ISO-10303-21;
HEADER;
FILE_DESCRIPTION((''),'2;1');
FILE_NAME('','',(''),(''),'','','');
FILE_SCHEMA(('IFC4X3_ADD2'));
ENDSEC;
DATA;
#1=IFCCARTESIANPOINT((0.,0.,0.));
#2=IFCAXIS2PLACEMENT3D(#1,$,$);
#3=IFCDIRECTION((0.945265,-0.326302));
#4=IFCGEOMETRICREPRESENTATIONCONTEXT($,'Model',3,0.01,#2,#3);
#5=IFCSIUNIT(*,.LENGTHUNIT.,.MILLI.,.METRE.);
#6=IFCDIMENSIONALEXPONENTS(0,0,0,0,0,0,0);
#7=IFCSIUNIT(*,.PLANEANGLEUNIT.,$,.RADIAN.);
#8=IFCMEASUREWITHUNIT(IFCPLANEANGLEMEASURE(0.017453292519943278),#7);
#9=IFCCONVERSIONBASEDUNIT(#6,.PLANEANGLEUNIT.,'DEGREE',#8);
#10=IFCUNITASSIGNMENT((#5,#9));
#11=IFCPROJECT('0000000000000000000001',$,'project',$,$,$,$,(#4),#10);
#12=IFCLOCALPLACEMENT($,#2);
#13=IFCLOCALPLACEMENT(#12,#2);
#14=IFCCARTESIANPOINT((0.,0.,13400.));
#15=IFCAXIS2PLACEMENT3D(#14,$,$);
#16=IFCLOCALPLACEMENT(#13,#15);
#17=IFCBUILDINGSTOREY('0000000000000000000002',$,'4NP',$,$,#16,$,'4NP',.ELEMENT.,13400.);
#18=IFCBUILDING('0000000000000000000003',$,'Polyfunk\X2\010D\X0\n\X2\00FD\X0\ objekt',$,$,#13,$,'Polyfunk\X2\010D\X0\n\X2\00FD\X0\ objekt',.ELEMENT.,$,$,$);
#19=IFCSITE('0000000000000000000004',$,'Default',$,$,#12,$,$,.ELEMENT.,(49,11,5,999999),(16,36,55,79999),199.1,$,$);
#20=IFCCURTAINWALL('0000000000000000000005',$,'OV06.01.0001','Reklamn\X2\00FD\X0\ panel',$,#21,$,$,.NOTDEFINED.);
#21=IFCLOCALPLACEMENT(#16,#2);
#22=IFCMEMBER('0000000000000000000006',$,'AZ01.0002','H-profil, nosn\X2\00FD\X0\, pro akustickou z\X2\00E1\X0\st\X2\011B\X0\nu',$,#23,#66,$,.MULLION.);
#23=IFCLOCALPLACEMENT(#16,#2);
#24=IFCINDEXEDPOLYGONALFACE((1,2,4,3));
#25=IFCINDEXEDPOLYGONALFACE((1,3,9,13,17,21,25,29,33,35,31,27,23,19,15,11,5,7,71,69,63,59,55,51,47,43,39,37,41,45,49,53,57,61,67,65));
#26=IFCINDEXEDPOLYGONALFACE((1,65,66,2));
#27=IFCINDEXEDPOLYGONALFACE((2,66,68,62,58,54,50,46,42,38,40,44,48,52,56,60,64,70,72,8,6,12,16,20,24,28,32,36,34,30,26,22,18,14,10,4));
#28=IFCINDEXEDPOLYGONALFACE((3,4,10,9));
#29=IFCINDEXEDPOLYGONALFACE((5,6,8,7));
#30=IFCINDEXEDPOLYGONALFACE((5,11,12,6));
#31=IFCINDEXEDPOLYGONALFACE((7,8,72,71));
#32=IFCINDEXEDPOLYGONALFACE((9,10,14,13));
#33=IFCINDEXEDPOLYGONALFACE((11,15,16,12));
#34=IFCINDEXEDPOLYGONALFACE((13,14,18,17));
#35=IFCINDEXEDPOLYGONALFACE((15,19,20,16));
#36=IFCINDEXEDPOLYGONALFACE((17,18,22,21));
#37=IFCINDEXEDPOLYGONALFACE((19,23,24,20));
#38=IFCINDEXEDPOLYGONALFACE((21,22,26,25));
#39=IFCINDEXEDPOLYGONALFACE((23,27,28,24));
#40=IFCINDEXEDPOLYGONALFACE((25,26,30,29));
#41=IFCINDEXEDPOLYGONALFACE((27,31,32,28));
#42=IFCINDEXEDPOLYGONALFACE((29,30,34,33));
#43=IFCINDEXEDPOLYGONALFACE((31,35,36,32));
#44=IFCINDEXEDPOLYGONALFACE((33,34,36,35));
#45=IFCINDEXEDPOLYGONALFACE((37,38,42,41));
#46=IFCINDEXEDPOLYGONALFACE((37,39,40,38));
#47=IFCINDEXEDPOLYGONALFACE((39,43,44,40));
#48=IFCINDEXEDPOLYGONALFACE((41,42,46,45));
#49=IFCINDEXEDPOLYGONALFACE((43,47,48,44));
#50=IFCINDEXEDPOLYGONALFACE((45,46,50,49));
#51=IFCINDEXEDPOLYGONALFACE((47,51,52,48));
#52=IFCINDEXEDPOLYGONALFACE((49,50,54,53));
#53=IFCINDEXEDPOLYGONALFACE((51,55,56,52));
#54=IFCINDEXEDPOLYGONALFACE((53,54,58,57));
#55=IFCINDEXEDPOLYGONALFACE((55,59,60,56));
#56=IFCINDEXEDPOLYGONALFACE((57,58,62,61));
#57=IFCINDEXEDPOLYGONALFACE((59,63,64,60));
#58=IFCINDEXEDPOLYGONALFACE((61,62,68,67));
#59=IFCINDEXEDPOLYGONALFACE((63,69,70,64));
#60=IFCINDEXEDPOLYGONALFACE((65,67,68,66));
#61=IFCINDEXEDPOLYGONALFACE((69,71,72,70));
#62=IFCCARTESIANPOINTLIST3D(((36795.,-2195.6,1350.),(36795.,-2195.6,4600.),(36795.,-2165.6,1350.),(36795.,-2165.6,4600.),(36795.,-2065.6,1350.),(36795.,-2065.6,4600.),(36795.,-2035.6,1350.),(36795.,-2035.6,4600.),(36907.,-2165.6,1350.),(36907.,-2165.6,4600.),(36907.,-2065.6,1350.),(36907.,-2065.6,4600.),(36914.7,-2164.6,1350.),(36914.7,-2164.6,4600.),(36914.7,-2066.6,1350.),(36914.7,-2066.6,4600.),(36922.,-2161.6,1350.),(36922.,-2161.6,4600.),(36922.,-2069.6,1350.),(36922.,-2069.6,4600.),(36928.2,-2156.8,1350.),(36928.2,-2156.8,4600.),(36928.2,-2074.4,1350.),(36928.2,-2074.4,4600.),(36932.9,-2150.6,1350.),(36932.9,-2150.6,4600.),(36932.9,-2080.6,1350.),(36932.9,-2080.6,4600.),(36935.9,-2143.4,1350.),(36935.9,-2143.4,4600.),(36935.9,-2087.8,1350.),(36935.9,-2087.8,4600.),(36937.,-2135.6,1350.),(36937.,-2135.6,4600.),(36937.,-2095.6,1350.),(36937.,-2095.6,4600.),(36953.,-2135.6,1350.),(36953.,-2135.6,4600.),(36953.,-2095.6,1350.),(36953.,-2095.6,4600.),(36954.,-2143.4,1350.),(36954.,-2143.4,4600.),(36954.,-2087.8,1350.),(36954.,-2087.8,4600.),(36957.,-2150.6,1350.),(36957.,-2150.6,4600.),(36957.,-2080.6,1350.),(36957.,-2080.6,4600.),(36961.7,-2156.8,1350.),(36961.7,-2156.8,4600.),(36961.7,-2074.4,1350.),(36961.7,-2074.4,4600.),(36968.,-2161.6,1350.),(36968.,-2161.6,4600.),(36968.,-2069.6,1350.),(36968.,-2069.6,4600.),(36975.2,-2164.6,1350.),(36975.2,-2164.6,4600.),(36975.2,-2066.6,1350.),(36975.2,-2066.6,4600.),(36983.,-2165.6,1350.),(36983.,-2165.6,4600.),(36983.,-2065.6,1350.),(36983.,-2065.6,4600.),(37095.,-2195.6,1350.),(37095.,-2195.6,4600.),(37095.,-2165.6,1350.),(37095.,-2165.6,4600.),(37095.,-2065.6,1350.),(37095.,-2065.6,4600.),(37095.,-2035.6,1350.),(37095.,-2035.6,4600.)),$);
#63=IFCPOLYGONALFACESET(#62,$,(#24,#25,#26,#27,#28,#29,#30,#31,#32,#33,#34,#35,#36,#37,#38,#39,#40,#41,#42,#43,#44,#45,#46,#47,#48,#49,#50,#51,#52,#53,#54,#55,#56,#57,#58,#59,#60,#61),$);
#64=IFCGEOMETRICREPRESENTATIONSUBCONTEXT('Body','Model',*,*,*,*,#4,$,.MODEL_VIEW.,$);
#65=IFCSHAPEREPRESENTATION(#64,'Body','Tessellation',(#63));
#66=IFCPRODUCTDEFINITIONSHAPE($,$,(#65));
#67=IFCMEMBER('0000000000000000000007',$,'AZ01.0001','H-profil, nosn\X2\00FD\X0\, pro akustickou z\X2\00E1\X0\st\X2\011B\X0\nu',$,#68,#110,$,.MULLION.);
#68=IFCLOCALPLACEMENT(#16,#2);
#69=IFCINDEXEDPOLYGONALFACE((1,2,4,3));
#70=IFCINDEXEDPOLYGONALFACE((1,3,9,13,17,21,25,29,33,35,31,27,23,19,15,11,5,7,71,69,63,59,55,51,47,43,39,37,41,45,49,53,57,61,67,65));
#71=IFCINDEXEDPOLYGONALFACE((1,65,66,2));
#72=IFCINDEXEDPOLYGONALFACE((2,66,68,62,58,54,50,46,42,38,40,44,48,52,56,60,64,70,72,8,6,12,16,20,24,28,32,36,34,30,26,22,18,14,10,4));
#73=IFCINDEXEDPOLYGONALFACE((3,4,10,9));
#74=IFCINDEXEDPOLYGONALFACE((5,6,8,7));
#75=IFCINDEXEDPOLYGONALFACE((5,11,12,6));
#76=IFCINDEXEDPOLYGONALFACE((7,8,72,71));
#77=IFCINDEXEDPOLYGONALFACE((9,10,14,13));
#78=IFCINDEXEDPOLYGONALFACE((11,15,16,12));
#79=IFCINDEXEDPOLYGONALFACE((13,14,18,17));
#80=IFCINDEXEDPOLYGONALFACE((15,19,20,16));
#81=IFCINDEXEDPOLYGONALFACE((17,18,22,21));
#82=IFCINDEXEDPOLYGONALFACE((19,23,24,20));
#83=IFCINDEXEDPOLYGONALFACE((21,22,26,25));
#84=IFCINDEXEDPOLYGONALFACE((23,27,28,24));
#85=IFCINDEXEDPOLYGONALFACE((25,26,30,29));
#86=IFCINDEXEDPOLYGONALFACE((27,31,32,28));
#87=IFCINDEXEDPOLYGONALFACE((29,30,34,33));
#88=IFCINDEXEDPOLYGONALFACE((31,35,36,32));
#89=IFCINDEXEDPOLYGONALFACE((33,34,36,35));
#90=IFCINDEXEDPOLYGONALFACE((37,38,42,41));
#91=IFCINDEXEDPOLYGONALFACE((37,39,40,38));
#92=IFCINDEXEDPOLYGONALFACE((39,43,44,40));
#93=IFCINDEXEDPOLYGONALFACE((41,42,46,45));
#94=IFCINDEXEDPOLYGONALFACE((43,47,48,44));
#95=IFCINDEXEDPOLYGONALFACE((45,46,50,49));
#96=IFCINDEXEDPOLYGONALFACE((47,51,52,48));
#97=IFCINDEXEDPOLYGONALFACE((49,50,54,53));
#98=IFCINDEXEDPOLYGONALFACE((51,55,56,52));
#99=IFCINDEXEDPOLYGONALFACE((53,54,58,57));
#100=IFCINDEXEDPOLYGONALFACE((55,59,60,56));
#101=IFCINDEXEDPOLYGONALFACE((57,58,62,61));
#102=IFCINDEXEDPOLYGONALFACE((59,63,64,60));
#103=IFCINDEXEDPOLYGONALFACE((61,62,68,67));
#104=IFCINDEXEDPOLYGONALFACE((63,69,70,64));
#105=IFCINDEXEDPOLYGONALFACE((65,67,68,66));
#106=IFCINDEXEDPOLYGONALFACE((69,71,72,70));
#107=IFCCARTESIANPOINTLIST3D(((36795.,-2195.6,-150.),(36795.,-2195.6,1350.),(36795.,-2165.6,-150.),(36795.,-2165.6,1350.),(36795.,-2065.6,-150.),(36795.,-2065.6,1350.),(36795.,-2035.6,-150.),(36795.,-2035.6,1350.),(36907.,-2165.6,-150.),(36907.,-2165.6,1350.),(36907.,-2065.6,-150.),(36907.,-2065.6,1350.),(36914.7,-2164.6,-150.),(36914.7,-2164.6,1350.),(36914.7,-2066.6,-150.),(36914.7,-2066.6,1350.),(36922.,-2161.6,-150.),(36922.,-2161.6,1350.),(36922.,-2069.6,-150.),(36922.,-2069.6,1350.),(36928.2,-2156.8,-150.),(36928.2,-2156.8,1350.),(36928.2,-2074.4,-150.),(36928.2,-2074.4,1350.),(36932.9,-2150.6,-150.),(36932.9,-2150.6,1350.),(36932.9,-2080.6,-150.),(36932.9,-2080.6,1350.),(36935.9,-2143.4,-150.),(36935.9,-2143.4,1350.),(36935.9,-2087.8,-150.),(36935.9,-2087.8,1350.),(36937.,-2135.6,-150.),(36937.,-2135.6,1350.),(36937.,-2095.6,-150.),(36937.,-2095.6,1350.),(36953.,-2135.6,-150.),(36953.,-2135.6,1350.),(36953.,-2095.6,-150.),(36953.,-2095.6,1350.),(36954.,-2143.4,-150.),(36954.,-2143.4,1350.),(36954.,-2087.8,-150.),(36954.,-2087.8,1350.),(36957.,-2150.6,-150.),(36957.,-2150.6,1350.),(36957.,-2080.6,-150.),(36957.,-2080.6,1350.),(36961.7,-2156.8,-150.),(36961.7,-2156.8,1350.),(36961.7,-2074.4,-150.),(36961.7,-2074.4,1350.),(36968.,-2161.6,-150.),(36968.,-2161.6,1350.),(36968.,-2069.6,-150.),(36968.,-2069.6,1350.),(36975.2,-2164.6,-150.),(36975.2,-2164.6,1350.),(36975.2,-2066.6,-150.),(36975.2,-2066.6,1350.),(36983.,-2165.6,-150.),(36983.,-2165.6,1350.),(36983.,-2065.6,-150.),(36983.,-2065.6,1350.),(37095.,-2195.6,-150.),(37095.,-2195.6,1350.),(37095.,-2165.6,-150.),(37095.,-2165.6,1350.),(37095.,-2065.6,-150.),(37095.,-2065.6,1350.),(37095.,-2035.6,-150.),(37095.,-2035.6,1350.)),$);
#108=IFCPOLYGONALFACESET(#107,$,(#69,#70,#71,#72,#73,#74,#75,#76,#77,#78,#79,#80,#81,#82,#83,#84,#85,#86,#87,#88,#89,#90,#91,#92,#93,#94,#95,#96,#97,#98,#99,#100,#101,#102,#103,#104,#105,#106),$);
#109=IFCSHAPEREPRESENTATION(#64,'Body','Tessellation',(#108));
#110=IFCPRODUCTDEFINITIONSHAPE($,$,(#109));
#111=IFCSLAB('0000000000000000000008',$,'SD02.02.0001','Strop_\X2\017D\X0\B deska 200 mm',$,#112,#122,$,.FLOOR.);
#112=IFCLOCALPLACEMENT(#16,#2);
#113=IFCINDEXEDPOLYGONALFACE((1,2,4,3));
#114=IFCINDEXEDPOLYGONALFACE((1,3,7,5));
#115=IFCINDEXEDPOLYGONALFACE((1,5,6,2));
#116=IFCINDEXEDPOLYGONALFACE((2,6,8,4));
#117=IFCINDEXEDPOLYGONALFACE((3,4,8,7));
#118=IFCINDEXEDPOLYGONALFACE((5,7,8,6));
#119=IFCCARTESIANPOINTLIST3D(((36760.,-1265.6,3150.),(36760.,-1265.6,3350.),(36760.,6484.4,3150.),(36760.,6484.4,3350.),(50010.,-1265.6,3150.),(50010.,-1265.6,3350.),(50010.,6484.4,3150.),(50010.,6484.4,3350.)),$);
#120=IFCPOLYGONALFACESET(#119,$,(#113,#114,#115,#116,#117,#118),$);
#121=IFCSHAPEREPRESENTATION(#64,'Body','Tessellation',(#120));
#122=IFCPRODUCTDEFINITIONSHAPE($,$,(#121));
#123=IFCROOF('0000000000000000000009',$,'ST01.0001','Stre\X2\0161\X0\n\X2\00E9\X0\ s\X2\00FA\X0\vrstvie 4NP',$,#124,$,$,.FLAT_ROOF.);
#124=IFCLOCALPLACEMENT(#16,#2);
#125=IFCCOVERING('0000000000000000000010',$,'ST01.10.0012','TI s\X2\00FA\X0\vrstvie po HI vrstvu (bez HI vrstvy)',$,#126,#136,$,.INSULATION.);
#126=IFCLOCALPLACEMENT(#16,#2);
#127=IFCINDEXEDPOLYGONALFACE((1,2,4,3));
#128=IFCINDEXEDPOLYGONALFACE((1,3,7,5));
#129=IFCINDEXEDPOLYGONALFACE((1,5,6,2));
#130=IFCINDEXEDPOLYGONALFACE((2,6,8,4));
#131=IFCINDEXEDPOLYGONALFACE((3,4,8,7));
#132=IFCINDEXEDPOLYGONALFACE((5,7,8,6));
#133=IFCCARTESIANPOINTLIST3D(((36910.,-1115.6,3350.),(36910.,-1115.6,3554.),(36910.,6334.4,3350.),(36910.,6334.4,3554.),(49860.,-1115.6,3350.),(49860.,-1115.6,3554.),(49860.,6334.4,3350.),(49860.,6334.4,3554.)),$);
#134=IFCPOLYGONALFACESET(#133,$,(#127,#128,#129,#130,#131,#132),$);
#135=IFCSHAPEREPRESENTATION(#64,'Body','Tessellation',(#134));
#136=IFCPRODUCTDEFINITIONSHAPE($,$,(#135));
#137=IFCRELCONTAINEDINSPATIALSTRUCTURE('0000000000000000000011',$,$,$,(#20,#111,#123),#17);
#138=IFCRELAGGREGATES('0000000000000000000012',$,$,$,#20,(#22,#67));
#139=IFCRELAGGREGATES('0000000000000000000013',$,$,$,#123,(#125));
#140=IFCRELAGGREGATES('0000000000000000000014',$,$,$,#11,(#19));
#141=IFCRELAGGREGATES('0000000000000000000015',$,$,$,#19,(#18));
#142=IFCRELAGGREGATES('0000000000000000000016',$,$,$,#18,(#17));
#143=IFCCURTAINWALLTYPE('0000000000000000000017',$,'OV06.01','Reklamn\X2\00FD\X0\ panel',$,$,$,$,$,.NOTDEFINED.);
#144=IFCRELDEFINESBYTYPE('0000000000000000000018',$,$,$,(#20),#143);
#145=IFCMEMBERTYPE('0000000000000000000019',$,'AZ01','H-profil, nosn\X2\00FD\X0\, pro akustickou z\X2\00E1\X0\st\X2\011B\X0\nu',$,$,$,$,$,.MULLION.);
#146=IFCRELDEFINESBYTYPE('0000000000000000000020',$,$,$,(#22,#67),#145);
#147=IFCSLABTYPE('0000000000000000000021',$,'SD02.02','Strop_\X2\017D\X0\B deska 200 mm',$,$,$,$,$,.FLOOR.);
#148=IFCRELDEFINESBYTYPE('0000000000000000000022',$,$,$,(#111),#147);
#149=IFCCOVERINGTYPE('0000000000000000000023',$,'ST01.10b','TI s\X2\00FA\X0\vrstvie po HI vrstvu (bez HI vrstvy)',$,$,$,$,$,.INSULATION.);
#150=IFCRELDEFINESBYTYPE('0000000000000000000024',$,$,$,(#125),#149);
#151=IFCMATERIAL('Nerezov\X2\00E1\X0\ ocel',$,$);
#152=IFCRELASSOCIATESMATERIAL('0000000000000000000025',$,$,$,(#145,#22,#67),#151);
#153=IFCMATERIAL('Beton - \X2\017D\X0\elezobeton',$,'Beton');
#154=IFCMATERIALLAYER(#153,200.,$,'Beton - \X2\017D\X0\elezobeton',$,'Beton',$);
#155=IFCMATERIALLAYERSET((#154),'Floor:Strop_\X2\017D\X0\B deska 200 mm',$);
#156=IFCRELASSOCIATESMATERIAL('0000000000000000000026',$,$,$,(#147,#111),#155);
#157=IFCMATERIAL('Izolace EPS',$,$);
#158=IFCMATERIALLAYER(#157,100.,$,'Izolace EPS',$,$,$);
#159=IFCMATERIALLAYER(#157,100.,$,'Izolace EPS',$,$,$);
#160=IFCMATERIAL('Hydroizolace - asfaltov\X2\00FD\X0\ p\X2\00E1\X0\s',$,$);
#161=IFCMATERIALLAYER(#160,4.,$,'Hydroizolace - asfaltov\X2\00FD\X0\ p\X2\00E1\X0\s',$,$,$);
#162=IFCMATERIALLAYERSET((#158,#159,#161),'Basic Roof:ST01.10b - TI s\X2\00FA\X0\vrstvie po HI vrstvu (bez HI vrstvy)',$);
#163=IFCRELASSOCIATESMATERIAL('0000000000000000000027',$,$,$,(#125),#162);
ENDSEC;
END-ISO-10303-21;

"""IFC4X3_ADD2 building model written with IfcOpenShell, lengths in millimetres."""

from ifc_helpers import new_model, entity, si_unit, converted_unit, direction, frame, frame_2d, origin, origin_2d_with_axis, place, context, subcontext, project, spatial, polyline, circle_curve, parameter, trimmed, segment, composite_curve, rectangle, outline, extrude, source, transform, mapped, material, layer, layer_set, layer_usage, material_profile, profile_set, profile_usage, type_object, type_shapes, element, aggregate, save


model = new_model("IFC4X3_ADD2")

# Units and contexts
model_context = context("Model", 3, precision=0.01, world=origin(), true_north=direction((0.945265, -0.326302)))
body_context = subcontext(model_context, "Body", "Model", "MODEL_VIEW")
ifc_project = project(units=[si_unit("LENGTHUNIT", "METRE", prefix="MILLI"), converted_unit("PLANEANGLEUNIT", "DEGREE", entity("IfcPlaneAngleMeasure", 0.017453292519943278), si_unit("PLANEANGLEUNIT", "RADIAN"), dimensions=[0, 0, 0, 0, 0, 0, 0])], contexts=[model_context])

# Site, building, storey
site_placement = place(None, origin())
site = spatial("IfcSite", under=ifc_project, at=site_placement, Name="Default", CompositionType="ELEMENT", RefLatitude=(49, 11, 5, 999999), RefLongitude=(16, 36, 55, 79999), RefElevation=199.1)
building_placement = place(site_placement, origin())
building = spatial("IfcBuilding", under=site, at=building_placement, Name="Polyfunkčný objekt", LongName="Polyfunkčný objekt", CompositionType="ELEMENT")
storey_placement = place(building_placement, frame((0.0, 0.0, 13400.0)))
storey = spatial("IfcBuildingStorey", under=building, at=storey_placement, Name="4NP", LongName="4NP", CompositionType="ELEMENT", Elevation=13400.0)

# Curtain wall, members
curtain_wall_type = type_object("IfcCurtainWallType", Name="OV06.01", Description="Reklamný panel", PredefinedType="NOTDEFINED")
curtain_wall_placement = place(storey_placement, frame((0.0, 0.0, -13400.0)))
curtain_wall = element("IfcCurtainWall", 1, at=curtain_wall_placement, inside=storey, type_object=curtain_wall_type, Name="OV06.01.0001", Description="Reklamný panel", PredefinedType="NOTDEFINED")
ifc_material_1 = material(Name="Nerezová ocel")
ifc_material_profile = material_profile(ifc_material_1, outline(composite_curve([segment(polyline([(50.0, -150.0), (80.0, -150.0)]), True, "CONTINUOUS"), segment(polyline([(80.0, -150.0), (80.0, 150.0)]), True, "CONTINUOUS"), segment(polyline([(80.0, 150.0), (50.0, 150.0)]), True, "CONTINUOUS"), segment(polyline([(50.0, 150.0), (50.0, 38.0)]), True, "CONTINUOUS"), segment(trimmed(circle_curve(frame_2d((20.0, 38.0), x_axis=(0.0, 1.0)), 30.0), [parameter(180.0)], [parameter(270.0)], True, "PARAMETER"), False, "CONTINUOUS"), segment(polyline([(20.0, 8.0), (-20.0, 8.0)]), True, "CONTINUOUS"), segment(trimmed(circle_curve(frame_2d((-20.0, 38.0), x_axis=(0.0, 1.0)), 30.0), [parameter(90.0)], [parameter(180.0)], True, "PARAMETER"), False, "CONTINUOUS"), segment(polyline([(-50.0, 38.0), (-50.0, 150.0)]), True, "CONTINUOUS"), segment(polyline([(-50.0, 150.0), (-80.0, 150.0)]), True, "CONTINUOUS"), segment(polyline([(-80.0, 150.0), (-80.0, -150.0)]), True, "CONTINUOUS"), segment(polyline([(-80.0, -150.0), (-50.0, -150.0)]), True, "CONTINUOUS"), segment(polyline([(-50.0, -150.0), (-50.0, -38.0)]), True, "CONTINUOUS"), segment(trimmed(circle_curve(frame_2d((-20.0, -38.0), x_axis=(0.0, 1.0)), 30.0), [parameter(0.0)], [parameter(90.0)], True, "PARAMETER"), False, "CONTINUOUS"), segment(polyline([(-20.0, -8.0), (20.0, -8.0)]), True, "CONTINUOUS"), segment(trimmed(circle_curve(frame_2d((20.0, -38.0), x_axis=(0.0, 1.0)), 30.0), [parameter(270.0)], [parameter(0.0)], True, "PARAMETER"), False, "CONTINUOUS"), segment(polyline([(50.0, -38.0), (50.0, -150.0)]), True, "CONTINUOUS")], self_intersect=False)), Name="Profil zástena")
ifc_profile_set = profile_set([ifc_material_profile], Name="Profil zástena")
ifc_profile_usage = profile_usage(ifc_profile_set)
member_type = type_object("IfcMemberType", Name="AZ01", Description="H-profil, nosný, pro akustickou zástěnu", PredefinedType="MULLION", material=ifc_profile_set)
shared_shape_1 = source(origin(), body_context, "Body", "SweptSolid", [
    extrude(outline(composite_curve([segment(polyline([(50.0, -150.0), (80.0, -150.0)]), True, "CONTINUOUS"), segment(polyline([(80.0, -150.0), (80.0, 150.0)]), True, "CONTINUOUS"), segment(polyline([(80.0, 150.0), (50.0, 150.0)]), True, "CONTINUOUS"), segment(polyline([(50.0, 150.0), (50.0, 38.0)]), True, "CONTINUOUS"), segment(trimmed(circle_curve(frame_2d((20.0, 38.0), x_axis=(0.0, 1.0)), 30.0), [parameter(180.0)], [parameter(270.0)], True, "PARAMETER"), False, "CONTINUOUS"), segment(polyline([(20.0, 8.0), (-20.0, 8.0)]), True, "CONTINUOUS"), segment(trimmed(circle_curve(frame_2d((-20.0, 38.0), x_axis=(0.0, 1.0)), 30.0), [parameter(90.0)], [parameter(180.0)], True, "PARAMETER"), False, "CONTINUOUS"), segment(polyline([(-50.0, 38.0), (-50.0, 150.0)]), True, "CONTINUOUS"), segment(polyline([(-50.0, 150.0), (-80.0, 150.0)]), True, "CONTINUOUS"), segment(polyline([(-80.0, 150.0), (-80.0, -150.0)]), True, "CONTINUOUS"), segment(polyline([(-80.0, -150.0), (-50.0, -150.0)]), True, "CONTINUOUS"), segment(polyline([(-50.0, -150.0), (-50.0, -38.0)]), True, "CONTINUOUS"), segment(trimmed(circle_curve(frame_2d((-20.0, -38.0), x_axis=(0.0, 1.0)), 30.0), [parameter(0.0)], [parameter(90.0)], True, "PARAMETER"), False, "CONTINUOUS"), segment(polyline([(-20.0, -8.0), (20.0, -8.0)]), True, "CONTINUOUS"), segment(trimmed(circle_curve(frame_2d((20.0, -38.0), x_axis=(0.0, 1.0)), 30.0), [parameter(270.0)], [parameter(0.0)], True, "PARAMETER"), False, "CONTINUOUS"), segment(polyline([(50.0, -38.0), (50.0, -150.0)]), True, "CONTINUOUS")], self_intersect=False)), frame((-150.0, 0.0, -3250.0), z_axis=(0.0, 0.0, 1.0), x_axis=(0.0, 1.0, 0.0)), (0.0, 0.0, 1.0), 3250.0),
])
member_1_placement = place(curtain_wall_placement, frame((36795.0, -2115.6, 18000.0), z_axis=(0.0, 0.0, 1.0), x_axis=(-1.0, 0.0, 0.0)))
member_1 = element("IfcMember", 2, at=member_1_placement, type_object=member_type, material=ifc_profile_usage, Name="AZ01.0002", Description="H-profil, nosný, pro akustickou zástěnu", PredefinedType="MULLION", context=body_context, shape_type="MappedRepresentation", body=[
    mapped(shared_shape_1, transform((0.0, 0.0, 0.0), scale=1.0)),
])
shared_shape_2 = source(origin(), body_context, "Body", "SweptSolid", [
    extrude(outline(composite_curve([segment(polyline([(50.0, -150.0), (80.0, -150.0)]), True, "CONTINUOUS"), segment(polyline([(80.0, -150.0), (80.0, 150.0)]), True, "CONTINUOUS"), segment(polyline([(80.0, 150.0), (50.0, 150.0)]), True, "CONTINUOUS"), segment(polyline([(50.0, 150.0), (50.0, 38.0)]), True, "CONTINUOUS"), segment(trimmed(circle_curve(frame_2d((20.0, 38.0), x_axis=(0.0, 1.0)), 30.0), [parameter(180.0)], [parameter(270.0)], True, "PARAMETER"), False, "CONTINUOUS"), segment(polyline([(20.0, 8.0), (-20.0, 8.0)]), True, "CONTINUOUS"), segment(trimmed(circle_curve(frame_2d((-20.0, 38.0), x_axis=(0.0, 1.0)), 30.0), [parameter(90.0)], [parameter(180.0)], True, "PARAMETER"), False, "CONTINUOUS"), segment(polyline([(-50.0, 38.0), (-50.0, 150.0)]), True, "CONTINUOUS"), segment(polyline([(-50.0, 150.0), (-80.0, 150.0)]), True, "CONTINUOUS"), segment(polyline([(-80.0, 150.0), (-80.0, -150.0)]), True, "CONTINUOUS"), segment(polyline([(-80.0, -150.0), (-50.0, -150.0)]), True, "CONTINUOUS"), segment(polyline([(-50.0, -150.0), (-50.0, -38.0)]), True, "CONTINUOUS"), segment(trimmed(circle_curve(frame_2d((-20.0, -38.0), x_axis=(0.0, 1.0)), 30.0), [parameter(0.0)], [parameter(90.0)], True, "PARAMETER"), False, "CONTINUOUS"), segment(polyline([(-20.0, -8.0), (20.0, -8.0)]), True, "CONTINUOUS"), segment(trimmed(circle_curve(frame_2d((20.0, -38.0), x_axis=(0.0, 1.0)), 30.0), [parameter(270.0)], [parameter(0.0)], True, "PARAMETER"), False, "CONTINUOUS"), segment(polyline([(50.0, -38.0), (50.0, -150.0)]), True, "CONTINUOUS")], self_intersect=False)), frame((-150.0, 0.0, -1500.0), z_axis=(0.0, 0.0, 1.0), x_axis=(0.0, 1.0, 0.0)), (0.0, 0.0, 1.0), 1500.0),
])
type_shapes(member_type, [shared_shape_1, shared_shape_2])
member_2_placement = place(curtain_wall_placement, frame((36795.0, -2115.6, 14750.0), z_axis=(0.0, 0.0, 1.0), x_axis=(-1.0, 0.0, 0.0)))
member_2 = element("IfcMember", 3, at=member_2_placement, type_object=member_type, material=ifc_profile_usage, Name="AZ01.0001", Description="H-profil, nosný, pro akustickou zástěnu", PredefinedType="MULLION", context=body_context, shape_type="MappedRepresentation", body=[
    mapped(shared_shape_2, transform((0.0, 0.0, 0.0), scale=1.0)),
])
aggregate(curtain_wall, [member_1, member_2])

# Slab
ifc_material_2 = material(Name="Beton - Železobeton", Category="Beton")
ifc_layer_1 = layer(ifc_material_2, 200.0, Name="Beton - Železobeton", Category="Beton")
ifc_layer_set_1 = layer_set([ifc_layer_1], Name="Floor:Strop_ŽB deska 200 mm")
ifc_layer_usage_1 = layer_usage(ifc_layer_set_1, "AXIS3", "POSITIVE", 0.0)
slab_type = type_object("IfcSlabType", Name="SD02.02", Description="Strop_ŽB deska 200 mm", PredefinedType="FLOOR", material=ifc_layer_set_1)
slab_placement = place(storey_placement, origin())
element("IfcSlab", 4, at=slab_placement, inside=storey, type_object=slab_type, material=ifc_layer_usage_1, Name="SD02.02.0001", Description="Strop_ŽB deska 200 mm", PredefinedType="FLOOR", context=body_context, shape_type="SweptSolid", body=[
    extrude(rectangle(XDim=7750.0, YDim=13250.0, at=frame_2d((0.0, 0.0), x_axis=(1.0, 0.0))), frame((43385.0, 2609.4, 3350.0), z_axis=(0.0, 0.0, -1.0), x_axis=(0.0, 1.0, 0.0)), (0.0, 0.0, 1.0), 200.0),
])

# Roof, covering
roof = element("IfcRoof", 5, inside=storey, Name="ST01.0001", Description="Strešné súvrstvie 4NP", PredefinedType="FLAT_ROOF")
ifc_material_3 = material(Name="Izolace EPS")
ifc_layer_2 = layer(ifc_material_3, 100.0, Name="Izolace EPS")
ifc_layer_3 = layer(ifc_material_3, 100.0, Name="Izolace EPS")
ifc_material_4 = material(Name="Hydroizolace - asfaltový pás")
ifc_layer_4 = layer(ifc_material_4, 4.0, Name="Hydroizolace - asfaltový pás")
ifc_layer_set_2 = layer_set([ifc_layer_2, ifc_layer_3, ifc_layer_4], Name="Basic Roof:ST01.10b - TI súvrstvie po HI vrstvu (bez HI vrstvy)")
covering_type_1 = type_object("IfcCoveringType", Name="ST01.10b", Description="TI súvrstvie po HI vrstvu (bez HI vrstvy)", PredefinedType="INSULATION")
covering_1_placement = place(storey_placement, frame((36910.0, -1115.6, 3350.0)))
covering_1 = element("IfcCovering", 6, at=covering_1_placement, type_object=covering_type_1, material=ifc_layer_set_2, Name="ST01.10.0012", Description="TI súvrstvie po HI vrstvu (bez HI vrstvy)", PredefinedType="INSULATION", context=body_context, shape_type="SweptSolid", body=[
    extrude(rectangle(XDim=7450.0, YDim=12950.0, at=origin_2d_with_axis()), frame((6475.0, 3725.0, 0.0), z_axis=(0.0, 0.0, 1.0), x_axis=(0.0, -1.0, 0.0)), (0.0, 0.0, 1.0), 204.0),
])
aggregate(roof, [covering_1])

save(model, "model.ifc")
